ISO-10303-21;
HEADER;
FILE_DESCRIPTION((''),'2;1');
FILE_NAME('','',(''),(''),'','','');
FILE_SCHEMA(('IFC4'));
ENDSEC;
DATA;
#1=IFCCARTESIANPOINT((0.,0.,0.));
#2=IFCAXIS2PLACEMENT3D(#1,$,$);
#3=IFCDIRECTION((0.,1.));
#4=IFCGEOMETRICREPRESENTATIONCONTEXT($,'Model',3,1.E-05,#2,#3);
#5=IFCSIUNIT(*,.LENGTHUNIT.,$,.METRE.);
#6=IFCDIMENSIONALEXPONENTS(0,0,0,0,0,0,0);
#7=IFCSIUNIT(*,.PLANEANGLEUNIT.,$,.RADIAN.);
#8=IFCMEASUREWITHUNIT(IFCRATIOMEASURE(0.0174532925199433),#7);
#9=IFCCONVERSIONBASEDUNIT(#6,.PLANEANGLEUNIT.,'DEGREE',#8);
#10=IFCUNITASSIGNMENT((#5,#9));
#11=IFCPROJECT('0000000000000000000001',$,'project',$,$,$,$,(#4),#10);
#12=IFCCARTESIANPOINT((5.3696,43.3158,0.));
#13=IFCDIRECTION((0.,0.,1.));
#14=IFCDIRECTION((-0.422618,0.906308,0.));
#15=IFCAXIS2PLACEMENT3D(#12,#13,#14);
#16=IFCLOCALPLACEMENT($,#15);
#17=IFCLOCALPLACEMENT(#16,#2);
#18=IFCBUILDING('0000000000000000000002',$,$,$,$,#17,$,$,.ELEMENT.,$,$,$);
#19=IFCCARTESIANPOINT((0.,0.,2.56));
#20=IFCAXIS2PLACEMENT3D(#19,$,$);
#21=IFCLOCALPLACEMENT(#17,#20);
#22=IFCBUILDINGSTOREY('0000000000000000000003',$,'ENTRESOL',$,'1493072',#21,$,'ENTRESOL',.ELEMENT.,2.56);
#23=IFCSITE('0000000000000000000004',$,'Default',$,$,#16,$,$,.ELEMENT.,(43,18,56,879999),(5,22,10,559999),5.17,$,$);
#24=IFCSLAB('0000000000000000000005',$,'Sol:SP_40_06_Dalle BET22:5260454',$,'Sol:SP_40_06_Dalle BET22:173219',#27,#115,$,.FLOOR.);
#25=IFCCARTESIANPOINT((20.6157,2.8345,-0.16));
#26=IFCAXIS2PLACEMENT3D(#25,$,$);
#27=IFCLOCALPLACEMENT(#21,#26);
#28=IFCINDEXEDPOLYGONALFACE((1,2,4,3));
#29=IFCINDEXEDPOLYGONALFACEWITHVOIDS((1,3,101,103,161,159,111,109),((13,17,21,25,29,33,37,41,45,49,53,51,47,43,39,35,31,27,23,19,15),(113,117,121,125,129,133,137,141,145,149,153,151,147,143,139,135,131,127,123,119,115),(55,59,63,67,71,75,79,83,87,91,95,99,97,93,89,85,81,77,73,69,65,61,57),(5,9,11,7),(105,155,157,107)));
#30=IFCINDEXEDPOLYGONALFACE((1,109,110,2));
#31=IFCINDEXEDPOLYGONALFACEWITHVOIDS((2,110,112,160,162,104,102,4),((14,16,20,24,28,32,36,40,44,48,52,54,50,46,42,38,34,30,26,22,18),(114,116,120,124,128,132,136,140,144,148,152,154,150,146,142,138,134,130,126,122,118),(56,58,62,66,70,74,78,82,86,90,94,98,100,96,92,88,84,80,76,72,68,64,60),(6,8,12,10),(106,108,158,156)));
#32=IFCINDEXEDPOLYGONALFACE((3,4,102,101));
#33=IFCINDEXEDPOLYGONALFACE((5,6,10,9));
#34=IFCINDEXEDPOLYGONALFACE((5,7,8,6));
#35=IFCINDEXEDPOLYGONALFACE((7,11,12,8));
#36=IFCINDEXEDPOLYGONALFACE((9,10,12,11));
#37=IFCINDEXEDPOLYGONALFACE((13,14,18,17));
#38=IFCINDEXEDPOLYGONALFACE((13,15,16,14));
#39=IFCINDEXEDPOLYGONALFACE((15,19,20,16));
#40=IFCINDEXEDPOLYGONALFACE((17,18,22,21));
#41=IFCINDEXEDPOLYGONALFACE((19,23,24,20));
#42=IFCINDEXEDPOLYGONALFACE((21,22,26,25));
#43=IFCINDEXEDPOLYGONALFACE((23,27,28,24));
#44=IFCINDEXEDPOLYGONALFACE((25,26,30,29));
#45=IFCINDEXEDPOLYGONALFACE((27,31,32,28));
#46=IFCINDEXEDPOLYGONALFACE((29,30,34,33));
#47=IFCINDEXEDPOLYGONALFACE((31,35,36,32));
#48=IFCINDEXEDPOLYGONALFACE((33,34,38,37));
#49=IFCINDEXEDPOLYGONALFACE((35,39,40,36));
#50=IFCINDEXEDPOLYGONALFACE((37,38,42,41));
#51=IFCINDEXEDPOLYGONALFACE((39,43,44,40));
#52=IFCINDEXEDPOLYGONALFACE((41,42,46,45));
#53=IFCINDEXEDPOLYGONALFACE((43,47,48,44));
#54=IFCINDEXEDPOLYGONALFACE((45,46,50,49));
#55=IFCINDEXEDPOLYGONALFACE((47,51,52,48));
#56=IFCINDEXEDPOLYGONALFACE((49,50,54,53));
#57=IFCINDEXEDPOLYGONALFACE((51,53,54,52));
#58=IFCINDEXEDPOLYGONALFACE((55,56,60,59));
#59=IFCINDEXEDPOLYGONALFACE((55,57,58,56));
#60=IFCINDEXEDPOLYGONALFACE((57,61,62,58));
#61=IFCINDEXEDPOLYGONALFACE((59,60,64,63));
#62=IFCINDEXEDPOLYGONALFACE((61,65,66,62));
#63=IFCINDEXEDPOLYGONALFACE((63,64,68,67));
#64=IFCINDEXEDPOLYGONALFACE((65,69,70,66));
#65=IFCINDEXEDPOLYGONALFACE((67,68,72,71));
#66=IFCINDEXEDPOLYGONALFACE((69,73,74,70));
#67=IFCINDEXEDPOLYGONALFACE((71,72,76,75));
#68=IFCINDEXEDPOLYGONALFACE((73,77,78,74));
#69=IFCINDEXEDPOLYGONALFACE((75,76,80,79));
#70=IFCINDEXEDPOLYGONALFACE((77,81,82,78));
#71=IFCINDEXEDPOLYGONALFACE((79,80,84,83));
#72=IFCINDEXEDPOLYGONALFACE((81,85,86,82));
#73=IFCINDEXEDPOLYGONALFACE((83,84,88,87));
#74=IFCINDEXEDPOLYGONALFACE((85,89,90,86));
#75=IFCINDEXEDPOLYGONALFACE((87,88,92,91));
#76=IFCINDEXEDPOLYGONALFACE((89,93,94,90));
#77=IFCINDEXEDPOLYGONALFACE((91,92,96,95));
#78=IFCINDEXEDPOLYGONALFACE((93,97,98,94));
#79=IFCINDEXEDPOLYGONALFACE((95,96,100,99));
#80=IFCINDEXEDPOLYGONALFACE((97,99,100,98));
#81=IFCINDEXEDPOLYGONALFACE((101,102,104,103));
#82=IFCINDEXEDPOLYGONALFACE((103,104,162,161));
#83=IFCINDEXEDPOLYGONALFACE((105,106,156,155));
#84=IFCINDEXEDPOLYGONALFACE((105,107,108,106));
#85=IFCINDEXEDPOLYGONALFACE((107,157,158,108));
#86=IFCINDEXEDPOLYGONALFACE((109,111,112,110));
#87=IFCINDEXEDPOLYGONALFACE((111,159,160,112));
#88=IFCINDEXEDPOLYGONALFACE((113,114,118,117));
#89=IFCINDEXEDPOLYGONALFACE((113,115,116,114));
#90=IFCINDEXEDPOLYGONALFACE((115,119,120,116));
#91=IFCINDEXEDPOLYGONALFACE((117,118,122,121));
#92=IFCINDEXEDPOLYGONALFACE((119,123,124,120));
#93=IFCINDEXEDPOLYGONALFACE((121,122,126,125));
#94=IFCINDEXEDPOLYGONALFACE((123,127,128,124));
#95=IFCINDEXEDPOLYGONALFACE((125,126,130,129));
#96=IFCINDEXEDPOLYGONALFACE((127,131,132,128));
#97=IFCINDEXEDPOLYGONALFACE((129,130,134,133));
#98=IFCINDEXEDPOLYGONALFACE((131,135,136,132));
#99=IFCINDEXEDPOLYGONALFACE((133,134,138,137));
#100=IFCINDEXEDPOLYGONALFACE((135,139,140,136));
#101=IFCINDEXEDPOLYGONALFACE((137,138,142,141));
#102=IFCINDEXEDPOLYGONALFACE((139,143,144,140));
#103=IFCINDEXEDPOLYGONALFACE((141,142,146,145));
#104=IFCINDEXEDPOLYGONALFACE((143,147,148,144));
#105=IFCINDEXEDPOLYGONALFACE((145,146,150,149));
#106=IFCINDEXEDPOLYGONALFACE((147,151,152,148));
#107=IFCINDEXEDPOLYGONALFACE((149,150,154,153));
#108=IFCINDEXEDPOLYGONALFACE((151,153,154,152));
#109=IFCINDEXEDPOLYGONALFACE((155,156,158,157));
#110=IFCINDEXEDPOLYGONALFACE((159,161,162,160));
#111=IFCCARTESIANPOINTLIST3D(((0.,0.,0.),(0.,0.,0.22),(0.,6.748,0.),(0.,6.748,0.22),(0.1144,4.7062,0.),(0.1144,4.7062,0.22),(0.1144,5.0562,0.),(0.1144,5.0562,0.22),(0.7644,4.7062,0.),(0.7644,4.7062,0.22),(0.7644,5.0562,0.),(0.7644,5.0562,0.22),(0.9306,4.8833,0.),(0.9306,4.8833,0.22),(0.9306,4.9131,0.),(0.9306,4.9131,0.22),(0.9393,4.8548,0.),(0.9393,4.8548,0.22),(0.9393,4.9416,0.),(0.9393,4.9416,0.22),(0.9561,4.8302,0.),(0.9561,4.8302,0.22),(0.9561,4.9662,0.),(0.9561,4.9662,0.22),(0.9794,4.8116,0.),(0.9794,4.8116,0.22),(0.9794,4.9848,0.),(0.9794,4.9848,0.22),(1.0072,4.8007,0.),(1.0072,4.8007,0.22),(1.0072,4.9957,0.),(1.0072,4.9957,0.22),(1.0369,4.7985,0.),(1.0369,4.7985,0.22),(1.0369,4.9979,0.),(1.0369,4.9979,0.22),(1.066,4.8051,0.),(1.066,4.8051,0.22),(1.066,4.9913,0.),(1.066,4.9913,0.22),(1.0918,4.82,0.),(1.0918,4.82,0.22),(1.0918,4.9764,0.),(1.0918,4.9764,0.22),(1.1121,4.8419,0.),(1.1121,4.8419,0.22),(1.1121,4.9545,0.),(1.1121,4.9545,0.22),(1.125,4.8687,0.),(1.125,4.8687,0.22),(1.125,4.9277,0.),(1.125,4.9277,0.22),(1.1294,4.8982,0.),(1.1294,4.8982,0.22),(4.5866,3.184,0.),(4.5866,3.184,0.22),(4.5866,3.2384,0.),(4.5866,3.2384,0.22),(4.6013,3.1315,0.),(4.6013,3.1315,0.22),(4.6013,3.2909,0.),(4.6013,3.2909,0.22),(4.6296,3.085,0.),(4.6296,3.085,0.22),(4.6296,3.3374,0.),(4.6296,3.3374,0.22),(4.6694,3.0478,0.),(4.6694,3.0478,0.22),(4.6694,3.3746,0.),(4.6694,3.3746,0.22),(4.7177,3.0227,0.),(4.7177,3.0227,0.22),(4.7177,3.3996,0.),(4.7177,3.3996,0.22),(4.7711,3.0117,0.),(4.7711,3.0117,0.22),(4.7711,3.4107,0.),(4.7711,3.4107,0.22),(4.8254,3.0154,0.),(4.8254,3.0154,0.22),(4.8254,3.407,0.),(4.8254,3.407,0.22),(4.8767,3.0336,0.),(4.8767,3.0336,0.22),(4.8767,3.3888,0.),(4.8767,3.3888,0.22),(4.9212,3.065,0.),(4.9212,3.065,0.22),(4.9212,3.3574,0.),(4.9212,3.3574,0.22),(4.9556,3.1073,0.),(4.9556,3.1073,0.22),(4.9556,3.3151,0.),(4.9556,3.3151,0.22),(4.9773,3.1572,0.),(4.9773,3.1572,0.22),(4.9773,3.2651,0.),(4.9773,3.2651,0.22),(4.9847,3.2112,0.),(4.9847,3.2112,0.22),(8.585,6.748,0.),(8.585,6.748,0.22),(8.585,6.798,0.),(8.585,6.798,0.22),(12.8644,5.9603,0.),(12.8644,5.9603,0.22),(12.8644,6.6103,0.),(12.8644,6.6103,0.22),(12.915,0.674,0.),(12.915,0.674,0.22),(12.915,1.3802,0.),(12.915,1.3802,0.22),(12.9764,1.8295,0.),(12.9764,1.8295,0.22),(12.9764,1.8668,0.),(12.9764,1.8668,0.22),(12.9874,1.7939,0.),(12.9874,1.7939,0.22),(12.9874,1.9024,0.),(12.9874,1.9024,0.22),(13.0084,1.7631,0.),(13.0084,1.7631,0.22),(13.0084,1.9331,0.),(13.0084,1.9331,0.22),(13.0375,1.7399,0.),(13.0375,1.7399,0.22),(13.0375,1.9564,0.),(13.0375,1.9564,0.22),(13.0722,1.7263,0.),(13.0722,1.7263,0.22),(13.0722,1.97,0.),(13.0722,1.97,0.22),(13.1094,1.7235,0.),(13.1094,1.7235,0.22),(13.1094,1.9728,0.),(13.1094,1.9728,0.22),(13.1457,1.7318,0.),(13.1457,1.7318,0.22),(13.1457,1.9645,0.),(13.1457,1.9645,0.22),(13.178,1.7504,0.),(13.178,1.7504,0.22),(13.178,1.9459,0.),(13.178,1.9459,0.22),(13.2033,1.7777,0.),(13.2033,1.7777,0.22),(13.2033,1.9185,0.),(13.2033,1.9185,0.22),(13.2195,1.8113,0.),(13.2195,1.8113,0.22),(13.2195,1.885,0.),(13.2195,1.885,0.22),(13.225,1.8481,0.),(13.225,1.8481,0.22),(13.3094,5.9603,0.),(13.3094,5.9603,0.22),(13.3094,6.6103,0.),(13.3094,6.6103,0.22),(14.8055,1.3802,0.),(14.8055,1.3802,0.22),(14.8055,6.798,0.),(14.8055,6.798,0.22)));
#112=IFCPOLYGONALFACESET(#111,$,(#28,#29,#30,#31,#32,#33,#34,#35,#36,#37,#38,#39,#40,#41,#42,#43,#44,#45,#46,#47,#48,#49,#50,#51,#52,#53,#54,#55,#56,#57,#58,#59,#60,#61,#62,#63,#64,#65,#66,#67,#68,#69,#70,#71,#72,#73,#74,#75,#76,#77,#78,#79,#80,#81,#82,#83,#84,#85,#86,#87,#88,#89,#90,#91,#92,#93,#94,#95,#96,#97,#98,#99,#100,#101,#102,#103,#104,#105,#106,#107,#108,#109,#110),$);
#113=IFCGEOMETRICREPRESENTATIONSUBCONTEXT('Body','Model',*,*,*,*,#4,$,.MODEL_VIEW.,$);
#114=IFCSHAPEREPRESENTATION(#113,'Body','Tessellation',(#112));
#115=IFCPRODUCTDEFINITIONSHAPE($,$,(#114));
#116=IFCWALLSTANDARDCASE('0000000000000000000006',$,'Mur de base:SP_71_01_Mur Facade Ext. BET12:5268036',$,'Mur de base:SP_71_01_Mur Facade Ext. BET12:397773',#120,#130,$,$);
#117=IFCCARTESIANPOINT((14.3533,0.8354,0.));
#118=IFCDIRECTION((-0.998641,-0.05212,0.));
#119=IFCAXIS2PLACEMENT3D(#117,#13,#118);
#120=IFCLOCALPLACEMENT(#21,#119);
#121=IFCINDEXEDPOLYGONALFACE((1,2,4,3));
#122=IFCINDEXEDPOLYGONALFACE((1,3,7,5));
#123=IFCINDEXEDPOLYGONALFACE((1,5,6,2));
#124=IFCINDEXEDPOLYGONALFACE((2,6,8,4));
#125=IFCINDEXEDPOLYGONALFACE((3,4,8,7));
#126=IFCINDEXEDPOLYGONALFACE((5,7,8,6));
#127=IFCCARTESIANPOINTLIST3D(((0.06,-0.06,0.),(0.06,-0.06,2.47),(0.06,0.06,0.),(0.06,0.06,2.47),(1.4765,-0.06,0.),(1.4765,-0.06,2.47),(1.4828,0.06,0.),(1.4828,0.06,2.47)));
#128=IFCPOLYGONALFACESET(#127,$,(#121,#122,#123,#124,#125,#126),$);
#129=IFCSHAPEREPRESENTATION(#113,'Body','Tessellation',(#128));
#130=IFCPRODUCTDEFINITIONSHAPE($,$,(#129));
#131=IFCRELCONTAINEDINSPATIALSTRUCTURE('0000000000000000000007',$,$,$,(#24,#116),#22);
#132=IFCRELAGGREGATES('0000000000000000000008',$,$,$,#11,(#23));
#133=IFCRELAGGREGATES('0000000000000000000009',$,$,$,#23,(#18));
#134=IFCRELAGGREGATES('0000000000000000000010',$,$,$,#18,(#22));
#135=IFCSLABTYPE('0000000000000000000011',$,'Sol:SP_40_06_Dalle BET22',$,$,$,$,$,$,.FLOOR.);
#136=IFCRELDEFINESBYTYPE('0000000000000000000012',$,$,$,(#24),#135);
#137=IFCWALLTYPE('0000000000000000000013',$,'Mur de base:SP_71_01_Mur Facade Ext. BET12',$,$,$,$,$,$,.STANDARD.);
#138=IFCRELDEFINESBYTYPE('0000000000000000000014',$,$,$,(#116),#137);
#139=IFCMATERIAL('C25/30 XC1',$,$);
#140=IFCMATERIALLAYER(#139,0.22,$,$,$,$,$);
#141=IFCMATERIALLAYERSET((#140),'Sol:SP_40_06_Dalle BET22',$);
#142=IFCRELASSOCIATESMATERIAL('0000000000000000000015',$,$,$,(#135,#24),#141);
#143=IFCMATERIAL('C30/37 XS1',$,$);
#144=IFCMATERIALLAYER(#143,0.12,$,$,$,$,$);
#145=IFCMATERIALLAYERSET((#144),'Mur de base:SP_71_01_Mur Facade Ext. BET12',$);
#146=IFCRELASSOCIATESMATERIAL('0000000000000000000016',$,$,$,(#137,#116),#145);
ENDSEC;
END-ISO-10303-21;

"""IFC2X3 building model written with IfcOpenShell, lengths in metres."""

from ifc_helpers import new_model, entity, si_unit, converted_unit, direction, frame, origin, origin_2d_with_axis, place, context, subcontext, project, spatial, polyline, rectangle, circle, outline, extrude, clip, halfspace, material, layer, layer_set, layer_usage, type_object, element, save


model = new_model("IFC2X3")

# Units and contexts
model_context = context("Model", 3, precision=1e-05, world=origin(), true_north=direction((0.0, 1.0)))
body_context = subcontext(model_context, "Body", "Model", "MODEL_VIEW")
ifc_project = project(units=[si_unit("LENGTHUNIT", "METRE"), converted_unit("PLANEANGLEUNIT", "DEGREE", entity("IfcRatioMeasure", 0.0174532925199433), si_unit("PLANEANGLEUNIT", "RADIAN"), dimensions=[0, 0, 0, 0, 0, 0, 0])], contexts=[model_context])

# Site, building, storey
site_placement = place(None, frame((5.3696, 43.3158, 0.0), z_axis=(0.0, 0.0, 1.0), x_axis=(-0.422618, 0.906308, 0.0)))
site = spatial("IfcSite", under=ifc_project, at=site_placement, Name="Default", CompositionType="ELEMENT", RefLatitude=(43, 18, 56, 879999), RefLongitude=(5, 22, 10, 559999), RefElevation=5.17)
building_placement = place(site_placement, origin())
building = spatial("IfcBuilding", under=site, at=building_placement, CompositionType="ELEMENT")
storey_placement = place(building_placement, frame((0.0, 0.0, 2.56)))
storey = spatial("IfcBuildingStorey", under=building, at=storey_placement, Name="ENTRESOL", ObjectType="1493072", LongName="ENTRESOL", CompositionType="ELEMENT", Elevation=2.56)

# Slab, openings
ifc_material_1 = material(Name="C25/30 XC1")
ifc_layer_1 = layer(ifc_material_1, 0.22)
ifc_layer_set_1 = layer_set([ifc_layer_1], Name="Sol:SP_40_06_Dalle BET22")
ifc_layer_usage_1 = layer_usage(ifc_layer_set_1, "AXIS3", "POSITIVE", 0.0)
slab_type = type_object("IfcSlabType", Name="Sol:SP_40_06_Dalle BET22", PredefinedType="FLOOR", material=ifc_layer_set_1)
slab_placement = place(storey_placement, frame((20.6157, 2.8345, -0.16)))
slab = element("IfcSlab", 1, at=slab_placement, inside=storey, type_object=slab_type, material=ifc_layer_usage_1, Name="Sol:SP_40_06_Dalle BET22:5260454", ObjectType="Sol:SP_40_06_Dalle BET22:173219", PredefinedType="FLOOR", context=body_context, shape_type="SweptSolid", body=[
    extrude(outline(polyline([(-7.4028, -2.0189), (-5.5122, -2.0189), (-5.5122, -2.725), (7.4028, -3.399), (7.4028, 3.349), (-1.1822, 3.349), (-1.1822, 3.399), (-7.4028, 3.399), (-7.4028, -2.0189)])), frame((7.4028, 3.399, 0.22), z_axis=(0.0, 0.0, -1.0), x_axis=(-1.0, 0.0, 0.0)), (0.0, 0.0, 1.0), 0.22),
])
opening_1_placement = place(slab_placement, origin())
element("IfcOpeningElement", 2, at=opening_1_placement, cuts=slab, ObjectType="Opening", context=body_context, shape_type="SweptSolid", body=[
    extrude(rectangle(XDim=0.35, YDim=0.65, at=origin_2d_with_axis()), frame((0.4394, 4.8812, -0.08), z_axis=(0.0, 0.0, 1.0), x_axis=(0.0, 1.0, 0.0)), (0.0, 0.0, 1.0), 0.5),
])
opening_2_placement = place(slab_placement, origin())
element("IfcOpeningElement", 3, at=opening_2_placement, cuts=slab, ObjectType="Opening", context=body_context, shape_type="SweptSolid", body=[
    extrude(circle(Radius=0.2, at=origin_2d_with_axis()), frame((4.7847, 3.2112, -0.08)), (0.0, 0.0, 1.0), 0.5),
])
opening_3_placement = place(slab_placement, origin())
element("IfcOpeningElement", 4, at=opening_3_placement, cuts=slab, ObjectType="Opening", context=body_context, shape_type="SweptSolid", body=[
    extrude(circle(Radius=0.1, at=origin_2d_with_axis()), frame((1.0294, 4.8982, -0.08)), (0.0, 0.0, 1.0), 0.5),
])
opening_4_placement = place(slab_placement, origin())
element("IfcOpeningElement", 5, at=opening_4_placement, cuts=slab, ObjectType="Opening", context=body_context, shape_type="SweptSolid", body=[
    extrude(circle(Radius=0.125, at=origin_2d_with_axis()), frame((13.1, 1.8481, -0.08)), (0.0, 0.0, 1.0), 0.5),
])
opening_5_placement = place(slab_placement, origin())
element("IfcOpeningElement", 6, at=opening_5_placement, cuts=slab, ObjectType="Opening", context=body_context, shape_type="SweptSolid", body=[
    extrude(rectangle(XDim=0.445, YDim=0.65, at=origin_2d_with_axis()), frame((13.0869, 6.2853, -0.08), z_axis=(0.0, 0.0, 1.0), x_axis=(-1.0, 0.0, 0.0)), (0.0, 0.0, 1.0), 0.5),
])

# Shared definitions
ifc_material_2 = material(Name="C30/37 XS1")

# Wall
ifc_layer_2 = layer(ifc_material_2, 0.12)
ifc_layer_set_2 = layer_set([ifc_layer_2], Name="Mur de base:SP_71_01_Mur Facade Ext. BET12")
ifc_layer_usage_2 = layer_usage(ifc_layer_set_2, "AXIS2", "NEGATIVE", 0.06)
wall_type_1 = type_object("IfcWallType", Name="Mur de base:SP_71_01_Mur Facade Ext. BET12", PredefinedType="STANDARD", material=ifc_layer_set_2)
wall_1_placement = place(storey_placement, frame((14.3533, 0.8354, 0.0), z_axis=(0.0, 0.0, 1.0), x_axis=(-0.998641, -0.05212, 0.0)))
element("IfcWallStandardCase", 7, at=wall_1_placement, inside=storey, type_object=wall_type_1, material=ifc_layer_usage_2, Name="Mur de base:SP_71_01_Mur Facade Ext. BET12:5268036", ObjectType="Mur de base:SP_71_01_Mur Facade Ext. BET12:397773", context=body_context, shape_type="Clipping", body=[
    clip(extrude(outline(polyline([(1.4765, -0.06), (1.4828, 0.06), (1.2324, 0.06), (0.06, 0.06), (0.06, -0.06), (1.2262, -0.06), (1.4765, -0.06)])), origin(), (0.0, 0.0, 1.0), 2.47), halfspace(frame((0.0, 0.0, -2.56)), True)),
])

save(model, "model.ifc")
